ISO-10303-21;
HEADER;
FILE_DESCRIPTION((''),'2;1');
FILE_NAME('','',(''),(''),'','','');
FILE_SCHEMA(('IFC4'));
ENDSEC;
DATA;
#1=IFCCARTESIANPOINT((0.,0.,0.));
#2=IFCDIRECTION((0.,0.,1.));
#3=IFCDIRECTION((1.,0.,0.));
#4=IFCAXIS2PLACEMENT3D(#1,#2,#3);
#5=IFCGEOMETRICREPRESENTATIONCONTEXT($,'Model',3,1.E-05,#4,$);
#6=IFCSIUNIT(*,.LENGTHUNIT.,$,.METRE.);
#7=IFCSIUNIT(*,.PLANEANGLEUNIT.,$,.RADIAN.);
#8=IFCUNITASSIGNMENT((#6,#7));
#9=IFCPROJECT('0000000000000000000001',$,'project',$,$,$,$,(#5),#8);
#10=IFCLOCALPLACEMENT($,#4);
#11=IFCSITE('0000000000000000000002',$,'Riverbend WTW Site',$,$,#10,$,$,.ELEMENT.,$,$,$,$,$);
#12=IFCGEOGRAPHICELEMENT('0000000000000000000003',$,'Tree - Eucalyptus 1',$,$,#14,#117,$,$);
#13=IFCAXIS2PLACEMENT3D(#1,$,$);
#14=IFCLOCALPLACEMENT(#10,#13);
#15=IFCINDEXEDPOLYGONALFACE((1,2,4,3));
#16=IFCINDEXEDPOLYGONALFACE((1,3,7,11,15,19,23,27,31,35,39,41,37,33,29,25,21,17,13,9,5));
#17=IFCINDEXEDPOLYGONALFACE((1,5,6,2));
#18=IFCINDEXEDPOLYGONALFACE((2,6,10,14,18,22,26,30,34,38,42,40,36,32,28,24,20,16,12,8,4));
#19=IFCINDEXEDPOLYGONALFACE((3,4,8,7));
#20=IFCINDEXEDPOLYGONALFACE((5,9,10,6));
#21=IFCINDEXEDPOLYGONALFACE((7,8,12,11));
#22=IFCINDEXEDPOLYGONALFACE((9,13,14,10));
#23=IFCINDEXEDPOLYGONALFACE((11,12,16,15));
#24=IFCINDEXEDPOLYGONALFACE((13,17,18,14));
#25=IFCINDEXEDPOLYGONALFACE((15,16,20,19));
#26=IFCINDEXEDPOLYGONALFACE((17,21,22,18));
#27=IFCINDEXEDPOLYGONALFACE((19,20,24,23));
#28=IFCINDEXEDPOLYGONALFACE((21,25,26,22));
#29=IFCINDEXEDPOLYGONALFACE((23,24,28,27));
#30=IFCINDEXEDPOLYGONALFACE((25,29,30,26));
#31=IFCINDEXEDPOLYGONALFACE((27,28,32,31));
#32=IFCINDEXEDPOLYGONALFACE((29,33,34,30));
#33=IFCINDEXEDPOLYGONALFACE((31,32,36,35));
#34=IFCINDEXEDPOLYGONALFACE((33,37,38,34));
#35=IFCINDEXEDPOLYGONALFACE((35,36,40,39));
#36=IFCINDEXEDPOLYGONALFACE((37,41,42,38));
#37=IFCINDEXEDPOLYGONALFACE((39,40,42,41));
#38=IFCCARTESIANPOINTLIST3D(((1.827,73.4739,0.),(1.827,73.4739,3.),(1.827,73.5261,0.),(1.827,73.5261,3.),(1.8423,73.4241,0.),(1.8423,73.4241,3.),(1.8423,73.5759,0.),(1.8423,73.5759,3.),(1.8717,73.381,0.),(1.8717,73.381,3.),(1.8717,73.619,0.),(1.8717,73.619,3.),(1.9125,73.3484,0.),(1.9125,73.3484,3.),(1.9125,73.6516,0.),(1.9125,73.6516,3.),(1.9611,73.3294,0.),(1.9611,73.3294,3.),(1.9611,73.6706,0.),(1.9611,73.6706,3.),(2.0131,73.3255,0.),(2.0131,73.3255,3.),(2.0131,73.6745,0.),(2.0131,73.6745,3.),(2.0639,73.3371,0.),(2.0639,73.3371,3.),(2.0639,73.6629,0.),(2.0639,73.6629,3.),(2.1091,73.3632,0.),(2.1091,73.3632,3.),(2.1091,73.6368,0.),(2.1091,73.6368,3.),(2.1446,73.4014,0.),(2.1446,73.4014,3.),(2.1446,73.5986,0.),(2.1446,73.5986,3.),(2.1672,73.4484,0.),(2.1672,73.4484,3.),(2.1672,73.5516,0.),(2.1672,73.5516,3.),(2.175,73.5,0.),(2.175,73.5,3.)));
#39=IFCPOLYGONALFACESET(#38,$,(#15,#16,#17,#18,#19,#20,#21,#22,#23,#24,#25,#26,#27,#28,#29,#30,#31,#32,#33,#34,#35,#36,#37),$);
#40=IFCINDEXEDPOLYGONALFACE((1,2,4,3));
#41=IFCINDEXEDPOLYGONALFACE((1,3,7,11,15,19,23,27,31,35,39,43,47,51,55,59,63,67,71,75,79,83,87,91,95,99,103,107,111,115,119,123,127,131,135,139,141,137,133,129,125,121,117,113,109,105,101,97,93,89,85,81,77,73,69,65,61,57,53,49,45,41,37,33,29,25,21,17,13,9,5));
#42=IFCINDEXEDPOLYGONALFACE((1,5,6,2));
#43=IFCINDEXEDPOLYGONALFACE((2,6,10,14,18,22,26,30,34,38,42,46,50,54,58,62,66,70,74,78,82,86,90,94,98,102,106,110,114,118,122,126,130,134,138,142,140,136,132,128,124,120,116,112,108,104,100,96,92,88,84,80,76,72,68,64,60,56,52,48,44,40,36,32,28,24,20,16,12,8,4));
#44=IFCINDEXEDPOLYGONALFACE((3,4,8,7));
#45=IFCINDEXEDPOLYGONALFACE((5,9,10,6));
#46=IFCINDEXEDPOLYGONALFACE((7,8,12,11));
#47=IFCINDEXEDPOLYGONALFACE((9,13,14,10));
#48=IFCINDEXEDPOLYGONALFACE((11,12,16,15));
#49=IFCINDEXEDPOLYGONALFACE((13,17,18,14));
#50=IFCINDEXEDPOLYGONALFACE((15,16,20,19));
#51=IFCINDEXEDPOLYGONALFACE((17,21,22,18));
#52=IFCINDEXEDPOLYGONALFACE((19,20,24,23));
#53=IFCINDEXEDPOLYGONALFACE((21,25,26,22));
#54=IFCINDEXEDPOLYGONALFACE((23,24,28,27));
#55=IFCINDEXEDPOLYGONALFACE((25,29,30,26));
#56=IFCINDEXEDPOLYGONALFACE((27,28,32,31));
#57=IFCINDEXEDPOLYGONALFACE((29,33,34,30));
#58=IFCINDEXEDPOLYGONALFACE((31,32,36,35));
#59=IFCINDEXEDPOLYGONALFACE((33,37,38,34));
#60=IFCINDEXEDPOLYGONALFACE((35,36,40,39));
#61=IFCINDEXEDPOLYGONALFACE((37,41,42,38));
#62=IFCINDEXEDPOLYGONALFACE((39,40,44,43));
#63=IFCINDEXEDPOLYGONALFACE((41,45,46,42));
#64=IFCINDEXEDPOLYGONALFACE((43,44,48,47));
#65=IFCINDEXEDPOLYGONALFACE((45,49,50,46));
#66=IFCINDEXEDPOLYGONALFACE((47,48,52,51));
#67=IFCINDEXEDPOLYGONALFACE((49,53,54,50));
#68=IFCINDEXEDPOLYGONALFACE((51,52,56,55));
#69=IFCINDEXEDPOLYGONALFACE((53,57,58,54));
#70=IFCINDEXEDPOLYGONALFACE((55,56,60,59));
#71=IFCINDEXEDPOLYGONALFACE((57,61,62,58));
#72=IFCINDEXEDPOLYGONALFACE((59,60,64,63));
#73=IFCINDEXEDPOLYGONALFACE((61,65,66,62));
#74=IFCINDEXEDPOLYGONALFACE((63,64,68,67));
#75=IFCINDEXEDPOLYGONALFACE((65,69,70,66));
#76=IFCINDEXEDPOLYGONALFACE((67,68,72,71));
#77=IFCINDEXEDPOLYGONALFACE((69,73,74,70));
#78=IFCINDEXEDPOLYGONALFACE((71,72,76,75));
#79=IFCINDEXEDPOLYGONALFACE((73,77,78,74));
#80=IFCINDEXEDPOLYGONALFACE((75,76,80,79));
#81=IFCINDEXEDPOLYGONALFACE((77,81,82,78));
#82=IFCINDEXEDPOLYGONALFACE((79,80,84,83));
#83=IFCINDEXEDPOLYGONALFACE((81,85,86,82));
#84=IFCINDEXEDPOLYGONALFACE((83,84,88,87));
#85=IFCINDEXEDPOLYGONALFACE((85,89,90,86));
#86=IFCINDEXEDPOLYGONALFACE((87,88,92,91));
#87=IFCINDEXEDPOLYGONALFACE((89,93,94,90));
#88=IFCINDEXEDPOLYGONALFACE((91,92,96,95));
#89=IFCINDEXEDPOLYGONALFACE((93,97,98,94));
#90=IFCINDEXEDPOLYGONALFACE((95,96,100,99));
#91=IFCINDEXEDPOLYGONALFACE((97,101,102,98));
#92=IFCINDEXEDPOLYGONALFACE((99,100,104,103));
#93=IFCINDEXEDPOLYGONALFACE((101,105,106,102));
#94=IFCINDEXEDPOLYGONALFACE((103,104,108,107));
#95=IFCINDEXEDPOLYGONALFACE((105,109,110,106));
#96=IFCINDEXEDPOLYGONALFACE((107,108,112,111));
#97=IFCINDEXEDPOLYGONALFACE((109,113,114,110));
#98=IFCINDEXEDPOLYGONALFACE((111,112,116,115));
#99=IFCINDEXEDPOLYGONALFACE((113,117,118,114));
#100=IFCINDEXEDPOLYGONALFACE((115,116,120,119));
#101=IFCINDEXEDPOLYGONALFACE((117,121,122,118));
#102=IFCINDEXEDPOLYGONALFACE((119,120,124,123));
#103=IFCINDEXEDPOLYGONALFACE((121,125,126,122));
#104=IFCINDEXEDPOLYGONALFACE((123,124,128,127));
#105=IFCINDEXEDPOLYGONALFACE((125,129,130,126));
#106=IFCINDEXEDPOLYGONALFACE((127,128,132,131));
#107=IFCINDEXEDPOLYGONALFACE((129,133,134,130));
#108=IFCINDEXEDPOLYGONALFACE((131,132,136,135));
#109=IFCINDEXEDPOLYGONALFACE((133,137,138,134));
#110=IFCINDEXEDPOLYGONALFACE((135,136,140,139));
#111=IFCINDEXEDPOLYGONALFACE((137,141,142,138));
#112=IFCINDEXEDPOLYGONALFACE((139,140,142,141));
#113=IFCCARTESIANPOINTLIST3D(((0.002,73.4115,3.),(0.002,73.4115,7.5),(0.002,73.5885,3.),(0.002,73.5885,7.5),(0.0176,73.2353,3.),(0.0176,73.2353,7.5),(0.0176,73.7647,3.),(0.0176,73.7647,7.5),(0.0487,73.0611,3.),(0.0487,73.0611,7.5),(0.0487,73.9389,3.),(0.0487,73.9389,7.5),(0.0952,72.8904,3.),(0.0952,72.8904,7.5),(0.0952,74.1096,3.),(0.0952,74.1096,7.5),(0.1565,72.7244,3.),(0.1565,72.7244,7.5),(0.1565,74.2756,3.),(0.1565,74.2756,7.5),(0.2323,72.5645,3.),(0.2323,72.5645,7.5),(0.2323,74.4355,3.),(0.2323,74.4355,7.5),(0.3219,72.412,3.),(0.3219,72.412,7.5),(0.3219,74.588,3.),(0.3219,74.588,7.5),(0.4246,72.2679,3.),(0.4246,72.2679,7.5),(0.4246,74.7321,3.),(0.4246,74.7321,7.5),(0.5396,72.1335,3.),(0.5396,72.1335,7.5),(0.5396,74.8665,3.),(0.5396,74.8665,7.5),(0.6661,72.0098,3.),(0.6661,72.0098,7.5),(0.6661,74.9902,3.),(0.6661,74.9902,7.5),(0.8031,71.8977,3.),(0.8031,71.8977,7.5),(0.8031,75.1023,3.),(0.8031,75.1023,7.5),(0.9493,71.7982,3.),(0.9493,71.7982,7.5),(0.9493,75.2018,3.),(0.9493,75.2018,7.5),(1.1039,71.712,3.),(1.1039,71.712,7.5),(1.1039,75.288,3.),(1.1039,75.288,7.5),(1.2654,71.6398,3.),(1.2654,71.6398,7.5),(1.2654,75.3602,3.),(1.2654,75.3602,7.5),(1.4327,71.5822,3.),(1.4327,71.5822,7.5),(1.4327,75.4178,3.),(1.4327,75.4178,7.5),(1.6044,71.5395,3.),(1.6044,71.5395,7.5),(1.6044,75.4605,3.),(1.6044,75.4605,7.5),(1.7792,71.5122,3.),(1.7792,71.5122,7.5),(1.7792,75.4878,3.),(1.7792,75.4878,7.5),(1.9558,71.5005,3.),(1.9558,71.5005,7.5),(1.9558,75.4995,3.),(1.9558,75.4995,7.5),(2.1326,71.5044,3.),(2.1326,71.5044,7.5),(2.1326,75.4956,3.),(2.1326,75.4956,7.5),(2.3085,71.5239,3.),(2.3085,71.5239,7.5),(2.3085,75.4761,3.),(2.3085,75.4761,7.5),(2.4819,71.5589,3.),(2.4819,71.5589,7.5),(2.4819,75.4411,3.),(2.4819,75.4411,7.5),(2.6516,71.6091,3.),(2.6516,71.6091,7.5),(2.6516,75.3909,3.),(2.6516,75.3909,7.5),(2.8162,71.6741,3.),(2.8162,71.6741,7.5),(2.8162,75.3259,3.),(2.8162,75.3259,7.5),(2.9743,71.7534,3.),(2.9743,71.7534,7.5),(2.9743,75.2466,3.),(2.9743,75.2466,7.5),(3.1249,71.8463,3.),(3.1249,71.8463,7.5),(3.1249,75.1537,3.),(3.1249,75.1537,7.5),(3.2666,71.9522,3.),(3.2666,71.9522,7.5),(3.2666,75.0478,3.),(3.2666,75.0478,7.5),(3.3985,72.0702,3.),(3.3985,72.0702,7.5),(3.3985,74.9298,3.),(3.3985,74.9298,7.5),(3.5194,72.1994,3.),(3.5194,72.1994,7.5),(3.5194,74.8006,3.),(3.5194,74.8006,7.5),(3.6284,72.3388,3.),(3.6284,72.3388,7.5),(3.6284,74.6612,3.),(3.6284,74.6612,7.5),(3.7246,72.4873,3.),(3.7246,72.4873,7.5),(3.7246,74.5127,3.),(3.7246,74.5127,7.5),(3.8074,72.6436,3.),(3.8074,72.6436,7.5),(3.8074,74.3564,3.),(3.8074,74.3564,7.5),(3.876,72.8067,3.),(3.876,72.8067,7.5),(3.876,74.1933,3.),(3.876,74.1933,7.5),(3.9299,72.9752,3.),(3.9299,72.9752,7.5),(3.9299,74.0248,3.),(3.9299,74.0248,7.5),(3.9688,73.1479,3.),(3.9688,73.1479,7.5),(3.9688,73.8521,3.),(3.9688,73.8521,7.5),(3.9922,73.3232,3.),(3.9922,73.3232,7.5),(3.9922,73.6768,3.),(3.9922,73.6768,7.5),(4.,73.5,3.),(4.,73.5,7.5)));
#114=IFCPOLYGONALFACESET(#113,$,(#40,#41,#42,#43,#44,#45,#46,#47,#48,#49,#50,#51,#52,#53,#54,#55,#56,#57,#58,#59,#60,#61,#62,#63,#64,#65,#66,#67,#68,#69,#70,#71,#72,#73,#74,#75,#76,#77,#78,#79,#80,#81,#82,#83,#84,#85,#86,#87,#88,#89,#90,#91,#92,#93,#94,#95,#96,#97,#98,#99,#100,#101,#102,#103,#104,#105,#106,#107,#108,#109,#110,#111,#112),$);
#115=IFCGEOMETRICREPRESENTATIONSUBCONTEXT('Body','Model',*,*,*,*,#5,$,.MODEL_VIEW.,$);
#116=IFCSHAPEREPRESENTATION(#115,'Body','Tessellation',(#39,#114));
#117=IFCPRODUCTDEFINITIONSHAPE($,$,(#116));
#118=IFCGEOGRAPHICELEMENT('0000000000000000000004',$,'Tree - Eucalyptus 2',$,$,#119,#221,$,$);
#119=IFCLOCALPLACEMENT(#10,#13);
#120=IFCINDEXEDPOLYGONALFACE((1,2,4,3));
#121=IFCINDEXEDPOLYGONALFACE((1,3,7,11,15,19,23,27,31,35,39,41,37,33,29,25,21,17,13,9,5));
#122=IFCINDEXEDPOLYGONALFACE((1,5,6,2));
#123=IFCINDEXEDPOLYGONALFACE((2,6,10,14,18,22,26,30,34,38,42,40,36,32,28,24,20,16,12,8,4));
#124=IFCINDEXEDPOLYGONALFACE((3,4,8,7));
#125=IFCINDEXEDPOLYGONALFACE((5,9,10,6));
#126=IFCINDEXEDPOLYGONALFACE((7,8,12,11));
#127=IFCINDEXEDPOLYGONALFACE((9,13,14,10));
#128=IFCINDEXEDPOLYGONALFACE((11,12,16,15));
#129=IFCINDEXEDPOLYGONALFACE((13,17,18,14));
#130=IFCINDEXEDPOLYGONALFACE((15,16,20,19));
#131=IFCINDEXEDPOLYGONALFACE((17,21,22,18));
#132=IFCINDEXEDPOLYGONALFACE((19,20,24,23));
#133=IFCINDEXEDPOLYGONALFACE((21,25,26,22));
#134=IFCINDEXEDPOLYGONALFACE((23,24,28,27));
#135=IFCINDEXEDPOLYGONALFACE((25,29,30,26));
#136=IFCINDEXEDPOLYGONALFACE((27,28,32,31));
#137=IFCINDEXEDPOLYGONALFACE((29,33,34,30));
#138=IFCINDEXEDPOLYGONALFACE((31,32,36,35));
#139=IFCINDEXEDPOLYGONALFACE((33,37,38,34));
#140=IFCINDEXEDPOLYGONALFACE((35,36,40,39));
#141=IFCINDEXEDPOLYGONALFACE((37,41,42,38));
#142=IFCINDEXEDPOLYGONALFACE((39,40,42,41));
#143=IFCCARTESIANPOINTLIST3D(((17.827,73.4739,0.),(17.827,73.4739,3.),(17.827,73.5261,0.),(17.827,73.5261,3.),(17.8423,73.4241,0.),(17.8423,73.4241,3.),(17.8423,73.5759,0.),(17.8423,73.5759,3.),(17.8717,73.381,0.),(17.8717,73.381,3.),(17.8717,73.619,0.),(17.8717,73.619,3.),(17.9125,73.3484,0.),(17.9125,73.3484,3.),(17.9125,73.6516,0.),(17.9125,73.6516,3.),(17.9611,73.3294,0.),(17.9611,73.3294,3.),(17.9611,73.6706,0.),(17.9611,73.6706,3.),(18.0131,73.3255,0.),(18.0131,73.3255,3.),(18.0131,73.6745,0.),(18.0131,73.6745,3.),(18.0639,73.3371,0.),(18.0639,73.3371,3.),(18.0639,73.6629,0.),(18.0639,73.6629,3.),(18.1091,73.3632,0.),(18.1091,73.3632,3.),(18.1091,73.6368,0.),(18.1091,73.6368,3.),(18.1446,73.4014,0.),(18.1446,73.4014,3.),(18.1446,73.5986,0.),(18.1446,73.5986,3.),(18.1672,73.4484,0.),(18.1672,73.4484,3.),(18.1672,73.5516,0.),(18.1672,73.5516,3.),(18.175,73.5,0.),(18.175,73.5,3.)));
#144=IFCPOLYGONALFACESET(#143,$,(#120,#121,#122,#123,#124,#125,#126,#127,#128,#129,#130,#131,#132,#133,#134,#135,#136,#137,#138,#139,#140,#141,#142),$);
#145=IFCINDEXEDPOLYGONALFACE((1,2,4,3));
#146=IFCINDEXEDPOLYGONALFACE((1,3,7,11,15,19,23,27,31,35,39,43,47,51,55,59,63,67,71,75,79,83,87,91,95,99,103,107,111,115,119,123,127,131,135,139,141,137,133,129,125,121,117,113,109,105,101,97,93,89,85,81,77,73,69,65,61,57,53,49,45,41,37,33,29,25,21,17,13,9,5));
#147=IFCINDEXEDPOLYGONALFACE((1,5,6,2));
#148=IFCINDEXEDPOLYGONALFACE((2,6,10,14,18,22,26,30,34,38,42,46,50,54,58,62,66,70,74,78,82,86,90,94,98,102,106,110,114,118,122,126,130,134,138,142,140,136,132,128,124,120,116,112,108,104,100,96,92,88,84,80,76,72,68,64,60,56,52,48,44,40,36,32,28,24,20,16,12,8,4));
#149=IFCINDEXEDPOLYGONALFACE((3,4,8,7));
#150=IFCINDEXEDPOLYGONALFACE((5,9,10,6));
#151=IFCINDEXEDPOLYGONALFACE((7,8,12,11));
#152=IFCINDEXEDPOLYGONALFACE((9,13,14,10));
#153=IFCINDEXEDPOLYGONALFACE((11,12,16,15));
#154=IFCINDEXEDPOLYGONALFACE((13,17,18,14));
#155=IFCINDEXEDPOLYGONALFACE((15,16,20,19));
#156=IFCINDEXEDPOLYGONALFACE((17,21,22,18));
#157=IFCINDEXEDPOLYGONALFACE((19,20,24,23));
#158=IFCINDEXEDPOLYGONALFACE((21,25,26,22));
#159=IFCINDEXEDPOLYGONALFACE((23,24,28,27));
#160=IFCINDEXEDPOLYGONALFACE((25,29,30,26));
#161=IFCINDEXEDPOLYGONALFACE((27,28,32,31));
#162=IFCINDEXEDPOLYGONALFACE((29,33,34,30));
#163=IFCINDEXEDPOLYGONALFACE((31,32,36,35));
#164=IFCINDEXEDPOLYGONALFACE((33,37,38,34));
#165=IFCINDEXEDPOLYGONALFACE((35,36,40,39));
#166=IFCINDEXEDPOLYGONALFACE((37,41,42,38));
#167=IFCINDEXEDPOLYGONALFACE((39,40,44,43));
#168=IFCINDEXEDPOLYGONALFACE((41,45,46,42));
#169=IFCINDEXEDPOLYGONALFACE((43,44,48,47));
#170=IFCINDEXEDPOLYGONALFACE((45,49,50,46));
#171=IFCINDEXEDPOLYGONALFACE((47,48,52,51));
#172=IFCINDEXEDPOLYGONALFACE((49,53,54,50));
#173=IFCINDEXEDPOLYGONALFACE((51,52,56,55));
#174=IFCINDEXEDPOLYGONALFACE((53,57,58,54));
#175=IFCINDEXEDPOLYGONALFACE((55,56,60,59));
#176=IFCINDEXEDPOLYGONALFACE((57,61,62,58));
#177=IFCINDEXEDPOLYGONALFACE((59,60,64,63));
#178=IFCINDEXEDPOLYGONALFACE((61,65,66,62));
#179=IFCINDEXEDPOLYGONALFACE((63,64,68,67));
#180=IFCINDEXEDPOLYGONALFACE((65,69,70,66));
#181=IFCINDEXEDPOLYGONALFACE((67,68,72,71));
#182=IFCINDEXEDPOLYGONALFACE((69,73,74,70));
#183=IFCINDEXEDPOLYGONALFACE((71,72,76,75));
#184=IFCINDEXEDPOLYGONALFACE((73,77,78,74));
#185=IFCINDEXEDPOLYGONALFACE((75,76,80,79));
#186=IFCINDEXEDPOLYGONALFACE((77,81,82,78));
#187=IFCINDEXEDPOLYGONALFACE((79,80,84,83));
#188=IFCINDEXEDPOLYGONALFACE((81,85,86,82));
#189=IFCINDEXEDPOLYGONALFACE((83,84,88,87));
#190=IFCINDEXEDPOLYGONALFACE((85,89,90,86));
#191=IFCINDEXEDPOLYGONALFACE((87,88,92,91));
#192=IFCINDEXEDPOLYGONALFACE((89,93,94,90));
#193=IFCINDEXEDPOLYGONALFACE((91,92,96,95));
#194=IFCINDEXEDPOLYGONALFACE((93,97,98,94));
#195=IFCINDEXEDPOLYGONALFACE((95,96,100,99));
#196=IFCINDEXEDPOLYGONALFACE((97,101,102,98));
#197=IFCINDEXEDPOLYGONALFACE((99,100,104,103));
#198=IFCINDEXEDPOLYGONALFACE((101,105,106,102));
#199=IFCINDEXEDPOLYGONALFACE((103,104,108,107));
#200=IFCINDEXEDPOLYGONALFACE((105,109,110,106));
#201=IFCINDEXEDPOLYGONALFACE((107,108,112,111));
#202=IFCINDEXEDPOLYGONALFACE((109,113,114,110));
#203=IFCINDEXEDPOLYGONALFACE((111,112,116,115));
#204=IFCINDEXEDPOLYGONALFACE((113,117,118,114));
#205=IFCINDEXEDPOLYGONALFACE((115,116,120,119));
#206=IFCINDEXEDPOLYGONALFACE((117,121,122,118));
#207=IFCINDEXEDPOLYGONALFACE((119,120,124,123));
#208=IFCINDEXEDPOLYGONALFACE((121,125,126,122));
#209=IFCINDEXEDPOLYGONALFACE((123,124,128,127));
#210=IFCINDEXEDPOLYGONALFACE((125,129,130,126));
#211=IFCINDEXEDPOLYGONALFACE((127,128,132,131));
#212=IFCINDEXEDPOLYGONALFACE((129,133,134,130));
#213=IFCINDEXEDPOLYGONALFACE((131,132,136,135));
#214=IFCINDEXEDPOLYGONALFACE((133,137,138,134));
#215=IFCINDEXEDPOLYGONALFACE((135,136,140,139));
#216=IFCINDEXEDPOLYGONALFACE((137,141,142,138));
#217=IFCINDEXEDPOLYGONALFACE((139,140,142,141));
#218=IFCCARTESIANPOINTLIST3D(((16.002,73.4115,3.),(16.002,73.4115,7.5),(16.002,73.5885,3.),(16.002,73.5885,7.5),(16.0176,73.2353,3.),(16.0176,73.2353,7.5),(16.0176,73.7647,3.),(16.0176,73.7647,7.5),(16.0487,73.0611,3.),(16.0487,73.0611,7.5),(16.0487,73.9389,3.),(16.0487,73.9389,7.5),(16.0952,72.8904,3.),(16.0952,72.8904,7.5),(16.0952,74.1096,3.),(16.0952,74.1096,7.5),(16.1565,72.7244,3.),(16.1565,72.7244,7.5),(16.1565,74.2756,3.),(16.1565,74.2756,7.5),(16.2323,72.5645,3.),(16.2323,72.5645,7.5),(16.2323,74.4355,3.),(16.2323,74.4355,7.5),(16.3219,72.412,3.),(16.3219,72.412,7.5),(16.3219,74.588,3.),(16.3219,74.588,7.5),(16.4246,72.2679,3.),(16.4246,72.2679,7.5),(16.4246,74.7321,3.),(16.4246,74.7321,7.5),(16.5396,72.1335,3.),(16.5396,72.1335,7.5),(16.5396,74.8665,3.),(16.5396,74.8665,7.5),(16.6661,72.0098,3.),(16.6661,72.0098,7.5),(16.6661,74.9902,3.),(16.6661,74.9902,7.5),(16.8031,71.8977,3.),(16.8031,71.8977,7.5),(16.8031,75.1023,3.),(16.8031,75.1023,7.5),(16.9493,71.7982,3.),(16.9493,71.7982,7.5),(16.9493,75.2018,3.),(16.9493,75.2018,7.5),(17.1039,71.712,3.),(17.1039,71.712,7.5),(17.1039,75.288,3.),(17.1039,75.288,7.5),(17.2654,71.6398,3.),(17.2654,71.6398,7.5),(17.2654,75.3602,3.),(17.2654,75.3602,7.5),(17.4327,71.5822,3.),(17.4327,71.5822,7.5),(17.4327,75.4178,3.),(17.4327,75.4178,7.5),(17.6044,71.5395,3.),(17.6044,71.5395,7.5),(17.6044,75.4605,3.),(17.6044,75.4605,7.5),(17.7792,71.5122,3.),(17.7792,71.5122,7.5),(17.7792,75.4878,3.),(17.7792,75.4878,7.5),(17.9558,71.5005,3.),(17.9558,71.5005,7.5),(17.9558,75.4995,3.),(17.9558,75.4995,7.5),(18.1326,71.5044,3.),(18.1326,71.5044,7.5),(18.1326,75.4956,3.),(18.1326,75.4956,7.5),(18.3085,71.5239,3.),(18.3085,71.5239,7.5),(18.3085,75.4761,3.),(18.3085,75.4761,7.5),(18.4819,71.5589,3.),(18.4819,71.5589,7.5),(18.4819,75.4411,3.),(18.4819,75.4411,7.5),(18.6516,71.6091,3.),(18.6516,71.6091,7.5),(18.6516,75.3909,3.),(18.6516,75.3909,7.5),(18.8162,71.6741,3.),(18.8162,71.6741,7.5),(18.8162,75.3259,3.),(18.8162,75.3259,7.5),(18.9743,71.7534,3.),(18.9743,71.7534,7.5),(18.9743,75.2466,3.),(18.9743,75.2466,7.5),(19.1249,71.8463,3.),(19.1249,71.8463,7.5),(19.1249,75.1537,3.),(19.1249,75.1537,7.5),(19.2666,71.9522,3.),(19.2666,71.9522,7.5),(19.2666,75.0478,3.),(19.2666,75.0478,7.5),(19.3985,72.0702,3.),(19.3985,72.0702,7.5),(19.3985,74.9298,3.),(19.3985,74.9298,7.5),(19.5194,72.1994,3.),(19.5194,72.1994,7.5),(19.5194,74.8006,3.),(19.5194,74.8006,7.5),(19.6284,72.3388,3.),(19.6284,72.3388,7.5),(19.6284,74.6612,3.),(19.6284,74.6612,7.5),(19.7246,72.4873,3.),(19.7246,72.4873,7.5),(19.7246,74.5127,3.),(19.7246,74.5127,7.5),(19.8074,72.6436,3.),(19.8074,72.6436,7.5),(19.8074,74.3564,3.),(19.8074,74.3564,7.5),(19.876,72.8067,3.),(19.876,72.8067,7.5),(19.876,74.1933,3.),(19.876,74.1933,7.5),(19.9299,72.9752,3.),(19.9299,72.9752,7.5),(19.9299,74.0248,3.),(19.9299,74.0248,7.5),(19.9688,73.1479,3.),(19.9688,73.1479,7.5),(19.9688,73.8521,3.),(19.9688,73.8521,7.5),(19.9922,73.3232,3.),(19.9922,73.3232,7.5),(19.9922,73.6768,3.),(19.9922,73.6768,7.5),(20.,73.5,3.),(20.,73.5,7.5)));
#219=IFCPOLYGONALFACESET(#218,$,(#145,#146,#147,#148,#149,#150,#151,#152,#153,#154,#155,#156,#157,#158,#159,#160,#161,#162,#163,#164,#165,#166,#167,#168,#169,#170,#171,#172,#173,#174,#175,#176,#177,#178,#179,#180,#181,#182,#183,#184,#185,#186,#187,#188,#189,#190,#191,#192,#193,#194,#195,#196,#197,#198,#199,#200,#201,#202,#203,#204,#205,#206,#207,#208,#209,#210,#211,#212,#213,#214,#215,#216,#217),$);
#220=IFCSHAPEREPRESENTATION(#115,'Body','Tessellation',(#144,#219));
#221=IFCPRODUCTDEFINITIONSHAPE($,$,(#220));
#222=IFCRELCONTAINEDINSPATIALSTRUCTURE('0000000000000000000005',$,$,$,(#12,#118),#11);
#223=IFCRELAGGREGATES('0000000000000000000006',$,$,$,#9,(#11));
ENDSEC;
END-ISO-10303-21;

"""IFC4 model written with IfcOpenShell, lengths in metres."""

from ifc_helpers import new_model, si_unit, frame, origin_with_axes, origin_2d, place, context, subcontext, project, spatial, circle, extrude, element, save


model = new_model("IFC4")

# Units and contexts
model_context = context("Model", 3, precision=1e-05, world=origin_with_axes())
body_context = subcontext(model_context, "Body", "Model", "MODEL_VIEW")
ifc_project = project(units=[si_unit("LENGTHUNIT", "METRE"), si_unit("PLANEANGLEUNIT", "RADIAN")], contexts=[model_context])

# Site
site_placement = place(None, origin_with_axes())
site = spatial("IfcSite", under=ifc_project, at=site_placement, Name="Riverbend WTW Site", CompositionType="ELEMENT")

# Geographic elements
for number, where, z_axis, x_axis, name in (
    (1, (2.0, 73.5, 0.0), (0.0, 0.0, 1.0), (1.0, 0.0, 0.0), "Tree - Eucalyptus 1"),
    (2, (18.0, 73.5, 0.0), (0.0, 0.0, 1.0), (1.0, 0.0, 0.0), "Tree - Eucalyptus 2"),
):
    element("IfcGeographicElement", number, at=place(None, frame(where, z_axis=z_axis, x_axis=x_axis)), inside=site, Name=name, context=body_context, shape_type="SweptSolid", body=[
        extrude(circle(Radius=0.175, at=origin_2d()), origin_with_axes(), (0.0, 0.0, 1.0), 3.0),
        extrude(circle(Radius=2.0, at=origin_2d()), frame((0.0, 0.0, 3.0), z_axis=(0.0, 0.0, 1.0), x_axis=(1.0, 0.0, 0.0)), (0.0, 0.0, 1.0), 4.5),
    ])

save(model, "model.ifc")
